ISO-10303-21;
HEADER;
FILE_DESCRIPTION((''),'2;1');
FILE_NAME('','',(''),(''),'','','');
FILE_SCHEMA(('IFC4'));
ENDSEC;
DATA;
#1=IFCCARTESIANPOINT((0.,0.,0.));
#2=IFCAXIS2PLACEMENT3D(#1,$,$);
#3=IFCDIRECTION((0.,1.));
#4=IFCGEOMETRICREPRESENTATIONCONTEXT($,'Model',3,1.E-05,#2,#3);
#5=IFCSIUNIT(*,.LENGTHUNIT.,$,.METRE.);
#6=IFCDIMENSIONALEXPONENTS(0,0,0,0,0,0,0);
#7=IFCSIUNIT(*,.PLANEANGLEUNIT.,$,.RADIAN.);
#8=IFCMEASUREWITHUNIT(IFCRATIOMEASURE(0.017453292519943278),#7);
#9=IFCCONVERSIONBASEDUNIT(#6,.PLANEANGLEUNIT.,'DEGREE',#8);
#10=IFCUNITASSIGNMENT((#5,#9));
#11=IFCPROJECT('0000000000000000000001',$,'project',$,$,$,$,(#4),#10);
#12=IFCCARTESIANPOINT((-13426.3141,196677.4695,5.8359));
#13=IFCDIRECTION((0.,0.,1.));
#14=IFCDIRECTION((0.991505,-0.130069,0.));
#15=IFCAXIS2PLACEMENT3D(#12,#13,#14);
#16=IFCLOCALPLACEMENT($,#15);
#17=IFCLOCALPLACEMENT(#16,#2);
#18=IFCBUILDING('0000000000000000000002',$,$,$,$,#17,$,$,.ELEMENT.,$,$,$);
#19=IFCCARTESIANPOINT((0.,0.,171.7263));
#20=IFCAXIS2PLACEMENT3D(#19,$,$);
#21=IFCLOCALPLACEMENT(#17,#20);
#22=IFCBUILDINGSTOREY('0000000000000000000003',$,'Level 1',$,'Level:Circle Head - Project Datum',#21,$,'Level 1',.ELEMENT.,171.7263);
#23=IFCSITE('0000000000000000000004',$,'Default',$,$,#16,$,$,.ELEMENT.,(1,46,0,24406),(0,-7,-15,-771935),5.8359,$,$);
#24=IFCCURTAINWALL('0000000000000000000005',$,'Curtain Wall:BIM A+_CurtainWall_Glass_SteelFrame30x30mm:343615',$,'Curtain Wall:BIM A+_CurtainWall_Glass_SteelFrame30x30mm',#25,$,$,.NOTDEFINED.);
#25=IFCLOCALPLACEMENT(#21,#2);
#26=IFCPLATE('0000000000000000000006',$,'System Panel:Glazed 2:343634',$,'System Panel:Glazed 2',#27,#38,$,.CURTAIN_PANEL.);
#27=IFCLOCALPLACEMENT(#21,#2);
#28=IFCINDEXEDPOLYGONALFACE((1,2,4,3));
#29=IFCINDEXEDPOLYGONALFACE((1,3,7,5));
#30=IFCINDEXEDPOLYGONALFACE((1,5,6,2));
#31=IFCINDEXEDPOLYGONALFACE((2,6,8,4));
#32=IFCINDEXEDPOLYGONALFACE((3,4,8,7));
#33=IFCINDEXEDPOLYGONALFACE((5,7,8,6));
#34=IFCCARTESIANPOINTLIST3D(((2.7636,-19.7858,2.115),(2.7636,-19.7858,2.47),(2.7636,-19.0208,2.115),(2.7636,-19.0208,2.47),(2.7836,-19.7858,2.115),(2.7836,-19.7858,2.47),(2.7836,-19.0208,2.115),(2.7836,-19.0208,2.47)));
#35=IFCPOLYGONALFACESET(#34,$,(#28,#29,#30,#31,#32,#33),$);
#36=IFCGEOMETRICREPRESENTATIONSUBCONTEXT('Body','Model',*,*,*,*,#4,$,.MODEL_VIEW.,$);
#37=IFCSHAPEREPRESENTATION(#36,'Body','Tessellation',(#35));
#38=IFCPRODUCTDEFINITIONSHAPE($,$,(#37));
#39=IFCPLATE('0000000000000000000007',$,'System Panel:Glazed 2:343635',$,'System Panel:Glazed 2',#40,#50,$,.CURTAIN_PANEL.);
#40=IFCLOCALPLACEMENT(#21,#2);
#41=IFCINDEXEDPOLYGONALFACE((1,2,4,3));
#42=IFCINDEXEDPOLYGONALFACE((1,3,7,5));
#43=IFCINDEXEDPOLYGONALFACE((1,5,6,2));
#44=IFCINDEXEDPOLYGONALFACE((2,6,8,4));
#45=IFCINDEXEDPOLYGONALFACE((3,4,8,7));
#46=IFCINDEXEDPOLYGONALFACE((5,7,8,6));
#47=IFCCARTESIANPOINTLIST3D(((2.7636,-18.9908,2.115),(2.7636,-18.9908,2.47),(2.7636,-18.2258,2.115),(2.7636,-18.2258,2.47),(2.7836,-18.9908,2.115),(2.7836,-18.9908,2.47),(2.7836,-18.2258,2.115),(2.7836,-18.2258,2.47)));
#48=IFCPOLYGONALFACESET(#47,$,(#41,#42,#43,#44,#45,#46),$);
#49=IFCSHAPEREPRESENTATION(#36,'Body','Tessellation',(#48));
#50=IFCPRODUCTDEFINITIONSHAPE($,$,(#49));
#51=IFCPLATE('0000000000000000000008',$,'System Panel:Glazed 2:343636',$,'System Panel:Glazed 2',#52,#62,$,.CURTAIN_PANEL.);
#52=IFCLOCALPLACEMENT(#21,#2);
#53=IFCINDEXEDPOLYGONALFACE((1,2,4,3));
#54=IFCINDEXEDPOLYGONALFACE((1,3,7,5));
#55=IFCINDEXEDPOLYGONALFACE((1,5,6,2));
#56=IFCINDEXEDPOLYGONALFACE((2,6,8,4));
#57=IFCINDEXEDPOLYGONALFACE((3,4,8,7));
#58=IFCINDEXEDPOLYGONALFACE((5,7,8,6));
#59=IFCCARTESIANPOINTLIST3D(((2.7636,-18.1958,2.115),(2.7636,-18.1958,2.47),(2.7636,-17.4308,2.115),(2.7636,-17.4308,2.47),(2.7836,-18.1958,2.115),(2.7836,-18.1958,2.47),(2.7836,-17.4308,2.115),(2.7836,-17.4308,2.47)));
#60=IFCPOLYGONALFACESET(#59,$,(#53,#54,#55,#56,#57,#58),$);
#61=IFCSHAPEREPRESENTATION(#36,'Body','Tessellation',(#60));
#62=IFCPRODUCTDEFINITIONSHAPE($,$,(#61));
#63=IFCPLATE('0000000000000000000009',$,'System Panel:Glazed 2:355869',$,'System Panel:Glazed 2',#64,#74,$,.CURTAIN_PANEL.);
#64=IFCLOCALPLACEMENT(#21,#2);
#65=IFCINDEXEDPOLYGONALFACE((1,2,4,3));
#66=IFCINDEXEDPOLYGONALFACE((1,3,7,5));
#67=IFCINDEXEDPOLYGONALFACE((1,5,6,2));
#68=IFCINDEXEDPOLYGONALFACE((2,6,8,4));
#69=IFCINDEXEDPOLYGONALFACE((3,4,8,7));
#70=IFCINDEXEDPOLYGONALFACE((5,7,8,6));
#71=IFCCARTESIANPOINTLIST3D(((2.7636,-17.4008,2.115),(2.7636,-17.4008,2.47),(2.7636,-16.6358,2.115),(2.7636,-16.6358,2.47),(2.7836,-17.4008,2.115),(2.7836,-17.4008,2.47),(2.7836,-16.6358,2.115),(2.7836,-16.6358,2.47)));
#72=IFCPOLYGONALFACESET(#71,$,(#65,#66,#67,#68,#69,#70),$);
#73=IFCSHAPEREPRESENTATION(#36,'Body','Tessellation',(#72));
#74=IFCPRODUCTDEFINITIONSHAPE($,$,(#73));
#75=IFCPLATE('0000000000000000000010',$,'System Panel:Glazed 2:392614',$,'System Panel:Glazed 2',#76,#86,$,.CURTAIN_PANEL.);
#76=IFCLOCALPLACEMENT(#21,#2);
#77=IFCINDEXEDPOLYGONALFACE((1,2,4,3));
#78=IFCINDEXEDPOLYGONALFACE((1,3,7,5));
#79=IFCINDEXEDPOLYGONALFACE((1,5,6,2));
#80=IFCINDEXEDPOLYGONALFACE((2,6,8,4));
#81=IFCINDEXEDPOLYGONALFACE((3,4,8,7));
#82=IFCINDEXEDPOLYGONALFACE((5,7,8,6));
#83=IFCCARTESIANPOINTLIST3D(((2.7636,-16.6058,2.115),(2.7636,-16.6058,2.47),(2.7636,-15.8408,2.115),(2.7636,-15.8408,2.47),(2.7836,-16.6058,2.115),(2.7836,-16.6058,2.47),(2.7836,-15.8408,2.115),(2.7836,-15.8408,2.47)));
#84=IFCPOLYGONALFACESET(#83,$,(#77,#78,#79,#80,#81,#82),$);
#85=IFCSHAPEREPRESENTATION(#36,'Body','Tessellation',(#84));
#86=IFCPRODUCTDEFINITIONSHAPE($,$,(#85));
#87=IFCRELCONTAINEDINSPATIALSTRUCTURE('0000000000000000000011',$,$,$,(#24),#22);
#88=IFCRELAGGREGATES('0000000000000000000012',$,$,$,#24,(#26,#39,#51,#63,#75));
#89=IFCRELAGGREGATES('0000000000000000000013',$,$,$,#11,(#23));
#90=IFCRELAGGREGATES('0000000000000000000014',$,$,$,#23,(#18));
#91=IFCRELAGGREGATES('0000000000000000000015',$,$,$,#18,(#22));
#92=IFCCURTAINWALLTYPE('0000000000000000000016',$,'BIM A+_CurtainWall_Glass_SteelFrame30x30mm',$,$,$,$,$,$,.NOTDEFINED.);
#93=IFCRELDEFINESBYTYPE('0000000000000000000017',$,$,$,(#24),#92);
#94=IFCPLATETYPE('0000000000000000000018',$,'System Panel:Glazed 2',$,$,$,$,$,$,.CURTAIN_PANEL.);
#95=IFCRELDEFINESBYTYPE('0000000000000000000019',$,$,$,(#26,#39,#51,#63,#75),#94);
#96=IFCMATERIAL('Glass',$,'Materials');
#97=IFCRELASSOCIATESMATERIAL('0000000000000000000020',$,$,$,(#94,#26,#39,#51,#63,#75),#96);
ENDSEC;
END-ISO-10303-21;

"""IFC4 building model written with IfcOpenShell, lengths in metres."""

from ifc_helpers import new_model, entity, si_unit, converted_unit, direction, frame, origin, place, context, subcontext, project, spatial, indexed_curve, outline, extrude, source, transform, mapped, material, type_object, type_shapes, element, aggregate, save


model = new_model("IFC4")

# Units and contexts
model_context = context("Model", 3, precision=1e-05, world=origin(), true_north=direction((0.0, 1.0)))
body_context = subcontext(model_context, "Body", "Model", "MODEL_VIEW")
ifc_project = project(units=[si_unit("LENGTHUNIT", "METRE"), converted_unit("PLANEANGLEUNIT", "DEGREE", entity("IfcRatioMeasure", 0.017453292519943278), si_unit("PLANEANGLEUNIT", "RADIAN"), dimensions=[0, 0, 0, 0, 0, 0, 0])], contexts=[model_context])

# Site, building, storey
site_placement = place(None, frame((-13426.3141, 196677.4695, 5.8359), z_axis=(0.0, 0.0, 1.0), x_axis=(0.991505, -0.130069, 0.0)))
site = spatial("IfcSite", under=ifc_project, at=site_placement, Name="Default", CompositionType="ELEMENT", RefLatitude=(1, 46, 0, 24406), RefLongitude=(0, -7, -15, -771935), RefElevation=5.8359)
building_placement = place(site_placement, origin())
building = spatial("IfcBuilding", under=site, at=building_placement, CompositionType="ELEMENT")
storey_placement = place(building_placement, frame((0.0, 0.0, 171.7263)))
storey = spatial("IfcBuildingStorey", under=building, at=storey_placement, Name="Level 1", ObjectType="Level:Circle Head - Project Datum", LongName="Level 1", CompositionType="ELEMENT", Elevation=171.7263)

# Curtain wall
curtain_wall_type_1 = type_object("IfcCurtainWallType", Name="BIM A+_CurtainWall_Glass_SteelFrame30x30mm", PredefinedType="NOTDEFINED")
curtain_wall_1_placement = place(storey_placement, frame((0.0, 0.0, -171.7263)))
curtain_wall_1 = element("IfcCurtainWall", 1, at=curtain_wall_1_placement, inside=storey, type_object=curtain_wall_type_1, Name="Curtain Wall:BIM A+_CurtainWall_Glass_SteelFrame30x30mm:343615", ObjectType="Curtain Wall:BIM A+_CurtainWall_Glass_SteelFrame30x30mm", PredefinedType="NOTDEFINED")

# Plates
ifc_material_1 = material(Name="Glass", Category="Materials")
plate_type_1 = type_object("IfcPlateType", Name="System Panel:Glazed 2", PredefinedType="CURTAIN_PANEL", material=ifc_material_1)
shared_shape_1 = source(origin(), body_context, "Body", "SweptSolid", [
    extrude(outline(indexed_curve([(-0.01, -0.3825), (0.01, -0.3825), (0.01, 0.3825), (-0.01, 0.3825), (-0.01, -0.3825)], self_intersect=False)), frame((0.0, 0.0, 0.0), z_axis=(0.0, 0.0, 1.0), x_axis=(0.0, 1.0, 0.0)), (0.0, 0.0, 1.0), 0.355),
])
type_shapes(plate_type_1, [shared_shape_1])
plate_1_placement = place(curtain_wall_1_placement, frame((2.7736, -19.4033, 173.8413), z_axis=(0.0, 0.0, 1.0), x_axis=(0.0, 1.0, 0.0)))
plate_1 = element("IfcPlate", 2, at=plate_1_placement, type_object=plate_type_1, material=ifc_material_1, Name="System Panel:Glazed 2:343634", ObjectType="System Panel:Glazed 2", PredefinedType="CURTAIN_PANEL", context=body_context, shape_type="MappedRepresentation", body=[
    mapped(shared_shape_1, transform((0.0, 0.0, 0.0), scale=1.0)),
])
plate_2_placement = place(curtain_wall_1_placement, frame((2.7736, -18.6083, 173.8413), z_axis=(0.0, 0.0, 1.0), x_axis=(0.0, 1.0, 0.0)))
plate_2 = element("IfcPlate", 3, at=plate_2_placement, type_object=plate_type_1, material=ifc_material_1, Name="System Panel:Glazed 2:343635", ObjectType="System Panel:Glazed 2", PredefinedType="CURTAIN_PANEL", context=body_context, shape_type="MappedRepresentation", body=[
    mapped(shared_shape_1, transform((0.0, 0.0, 0.0), scale=1.0)),
])
plate_3_placement = place(curtain_wall_1_placement, frame((2.7736, -17.8133, 173.8413), z_axis=(0.0, 0.0, 1.0), x_axis=(0.0, 1.0, 0.0)))
plate_3 = element("IfcPlate", 4, at=plate_3_placement, type_object=plate_type_1, material=ifc_material_1, Name="System Panel:Glazed 2:343636", ObjectType="System Panel:Glazed 2", PredefinedType="CURTAIN_PANEL", context=body_context, shape_type="MappedRepresentation", body=[
    mapped(shared_shape_1, transform((0.0, 0.0, 0.0), scale=1.0)),
])
plate_4_placement = place(curtain_wall_1_placement, frame((2.7736, -17.0183, 173.8413), z_axis=(0.0, 0.0, 1.0), x_axis=(0.0, 1.0, 0.0)))
plate_4 = element("IfcPlate", 5, at=plate_4_placement, type_object=plate_type_1, material=ifc_material_1, Name="System Panel:Glazed 2:355869", ObjectType="System Panel:Glazed 2", PredefinedType="CURTAIN_PANEL", context=body_context, shape_type="MappedRepresentation", body=[
    mapped(shared_shape_1, transform((0.0, 0.0, 0.0), scale=1.0)),
])
plate_5_placement = place(curtain_wall_1_placement, frame((2.7736, -16.2233, 173.8413), z_axis=(0.0, 0.0, 1.0), x_axis=(0.0, 1.0, 0.0)))
plate_5 = element("IfcPlate", 6, at=plate_5_placement, type_object=plate_type_1, material=ifc_material_1, Name="System Panel:Glazed 2:392614", ObjectType="System Panel:Glazed 2", PredefinedType="CURTAIN_PANEL", context=body_context, shape_type="MappedRepresentation", body=[
    mapped(shared_shape_1, transform((0.0, 0.0, 0.0), scale=1.0)),
])
aggregate(curtain_wall_1, [plate_1, plate_2, plate_3, plate_4, plate_5])

save(model, "model.ifc")
